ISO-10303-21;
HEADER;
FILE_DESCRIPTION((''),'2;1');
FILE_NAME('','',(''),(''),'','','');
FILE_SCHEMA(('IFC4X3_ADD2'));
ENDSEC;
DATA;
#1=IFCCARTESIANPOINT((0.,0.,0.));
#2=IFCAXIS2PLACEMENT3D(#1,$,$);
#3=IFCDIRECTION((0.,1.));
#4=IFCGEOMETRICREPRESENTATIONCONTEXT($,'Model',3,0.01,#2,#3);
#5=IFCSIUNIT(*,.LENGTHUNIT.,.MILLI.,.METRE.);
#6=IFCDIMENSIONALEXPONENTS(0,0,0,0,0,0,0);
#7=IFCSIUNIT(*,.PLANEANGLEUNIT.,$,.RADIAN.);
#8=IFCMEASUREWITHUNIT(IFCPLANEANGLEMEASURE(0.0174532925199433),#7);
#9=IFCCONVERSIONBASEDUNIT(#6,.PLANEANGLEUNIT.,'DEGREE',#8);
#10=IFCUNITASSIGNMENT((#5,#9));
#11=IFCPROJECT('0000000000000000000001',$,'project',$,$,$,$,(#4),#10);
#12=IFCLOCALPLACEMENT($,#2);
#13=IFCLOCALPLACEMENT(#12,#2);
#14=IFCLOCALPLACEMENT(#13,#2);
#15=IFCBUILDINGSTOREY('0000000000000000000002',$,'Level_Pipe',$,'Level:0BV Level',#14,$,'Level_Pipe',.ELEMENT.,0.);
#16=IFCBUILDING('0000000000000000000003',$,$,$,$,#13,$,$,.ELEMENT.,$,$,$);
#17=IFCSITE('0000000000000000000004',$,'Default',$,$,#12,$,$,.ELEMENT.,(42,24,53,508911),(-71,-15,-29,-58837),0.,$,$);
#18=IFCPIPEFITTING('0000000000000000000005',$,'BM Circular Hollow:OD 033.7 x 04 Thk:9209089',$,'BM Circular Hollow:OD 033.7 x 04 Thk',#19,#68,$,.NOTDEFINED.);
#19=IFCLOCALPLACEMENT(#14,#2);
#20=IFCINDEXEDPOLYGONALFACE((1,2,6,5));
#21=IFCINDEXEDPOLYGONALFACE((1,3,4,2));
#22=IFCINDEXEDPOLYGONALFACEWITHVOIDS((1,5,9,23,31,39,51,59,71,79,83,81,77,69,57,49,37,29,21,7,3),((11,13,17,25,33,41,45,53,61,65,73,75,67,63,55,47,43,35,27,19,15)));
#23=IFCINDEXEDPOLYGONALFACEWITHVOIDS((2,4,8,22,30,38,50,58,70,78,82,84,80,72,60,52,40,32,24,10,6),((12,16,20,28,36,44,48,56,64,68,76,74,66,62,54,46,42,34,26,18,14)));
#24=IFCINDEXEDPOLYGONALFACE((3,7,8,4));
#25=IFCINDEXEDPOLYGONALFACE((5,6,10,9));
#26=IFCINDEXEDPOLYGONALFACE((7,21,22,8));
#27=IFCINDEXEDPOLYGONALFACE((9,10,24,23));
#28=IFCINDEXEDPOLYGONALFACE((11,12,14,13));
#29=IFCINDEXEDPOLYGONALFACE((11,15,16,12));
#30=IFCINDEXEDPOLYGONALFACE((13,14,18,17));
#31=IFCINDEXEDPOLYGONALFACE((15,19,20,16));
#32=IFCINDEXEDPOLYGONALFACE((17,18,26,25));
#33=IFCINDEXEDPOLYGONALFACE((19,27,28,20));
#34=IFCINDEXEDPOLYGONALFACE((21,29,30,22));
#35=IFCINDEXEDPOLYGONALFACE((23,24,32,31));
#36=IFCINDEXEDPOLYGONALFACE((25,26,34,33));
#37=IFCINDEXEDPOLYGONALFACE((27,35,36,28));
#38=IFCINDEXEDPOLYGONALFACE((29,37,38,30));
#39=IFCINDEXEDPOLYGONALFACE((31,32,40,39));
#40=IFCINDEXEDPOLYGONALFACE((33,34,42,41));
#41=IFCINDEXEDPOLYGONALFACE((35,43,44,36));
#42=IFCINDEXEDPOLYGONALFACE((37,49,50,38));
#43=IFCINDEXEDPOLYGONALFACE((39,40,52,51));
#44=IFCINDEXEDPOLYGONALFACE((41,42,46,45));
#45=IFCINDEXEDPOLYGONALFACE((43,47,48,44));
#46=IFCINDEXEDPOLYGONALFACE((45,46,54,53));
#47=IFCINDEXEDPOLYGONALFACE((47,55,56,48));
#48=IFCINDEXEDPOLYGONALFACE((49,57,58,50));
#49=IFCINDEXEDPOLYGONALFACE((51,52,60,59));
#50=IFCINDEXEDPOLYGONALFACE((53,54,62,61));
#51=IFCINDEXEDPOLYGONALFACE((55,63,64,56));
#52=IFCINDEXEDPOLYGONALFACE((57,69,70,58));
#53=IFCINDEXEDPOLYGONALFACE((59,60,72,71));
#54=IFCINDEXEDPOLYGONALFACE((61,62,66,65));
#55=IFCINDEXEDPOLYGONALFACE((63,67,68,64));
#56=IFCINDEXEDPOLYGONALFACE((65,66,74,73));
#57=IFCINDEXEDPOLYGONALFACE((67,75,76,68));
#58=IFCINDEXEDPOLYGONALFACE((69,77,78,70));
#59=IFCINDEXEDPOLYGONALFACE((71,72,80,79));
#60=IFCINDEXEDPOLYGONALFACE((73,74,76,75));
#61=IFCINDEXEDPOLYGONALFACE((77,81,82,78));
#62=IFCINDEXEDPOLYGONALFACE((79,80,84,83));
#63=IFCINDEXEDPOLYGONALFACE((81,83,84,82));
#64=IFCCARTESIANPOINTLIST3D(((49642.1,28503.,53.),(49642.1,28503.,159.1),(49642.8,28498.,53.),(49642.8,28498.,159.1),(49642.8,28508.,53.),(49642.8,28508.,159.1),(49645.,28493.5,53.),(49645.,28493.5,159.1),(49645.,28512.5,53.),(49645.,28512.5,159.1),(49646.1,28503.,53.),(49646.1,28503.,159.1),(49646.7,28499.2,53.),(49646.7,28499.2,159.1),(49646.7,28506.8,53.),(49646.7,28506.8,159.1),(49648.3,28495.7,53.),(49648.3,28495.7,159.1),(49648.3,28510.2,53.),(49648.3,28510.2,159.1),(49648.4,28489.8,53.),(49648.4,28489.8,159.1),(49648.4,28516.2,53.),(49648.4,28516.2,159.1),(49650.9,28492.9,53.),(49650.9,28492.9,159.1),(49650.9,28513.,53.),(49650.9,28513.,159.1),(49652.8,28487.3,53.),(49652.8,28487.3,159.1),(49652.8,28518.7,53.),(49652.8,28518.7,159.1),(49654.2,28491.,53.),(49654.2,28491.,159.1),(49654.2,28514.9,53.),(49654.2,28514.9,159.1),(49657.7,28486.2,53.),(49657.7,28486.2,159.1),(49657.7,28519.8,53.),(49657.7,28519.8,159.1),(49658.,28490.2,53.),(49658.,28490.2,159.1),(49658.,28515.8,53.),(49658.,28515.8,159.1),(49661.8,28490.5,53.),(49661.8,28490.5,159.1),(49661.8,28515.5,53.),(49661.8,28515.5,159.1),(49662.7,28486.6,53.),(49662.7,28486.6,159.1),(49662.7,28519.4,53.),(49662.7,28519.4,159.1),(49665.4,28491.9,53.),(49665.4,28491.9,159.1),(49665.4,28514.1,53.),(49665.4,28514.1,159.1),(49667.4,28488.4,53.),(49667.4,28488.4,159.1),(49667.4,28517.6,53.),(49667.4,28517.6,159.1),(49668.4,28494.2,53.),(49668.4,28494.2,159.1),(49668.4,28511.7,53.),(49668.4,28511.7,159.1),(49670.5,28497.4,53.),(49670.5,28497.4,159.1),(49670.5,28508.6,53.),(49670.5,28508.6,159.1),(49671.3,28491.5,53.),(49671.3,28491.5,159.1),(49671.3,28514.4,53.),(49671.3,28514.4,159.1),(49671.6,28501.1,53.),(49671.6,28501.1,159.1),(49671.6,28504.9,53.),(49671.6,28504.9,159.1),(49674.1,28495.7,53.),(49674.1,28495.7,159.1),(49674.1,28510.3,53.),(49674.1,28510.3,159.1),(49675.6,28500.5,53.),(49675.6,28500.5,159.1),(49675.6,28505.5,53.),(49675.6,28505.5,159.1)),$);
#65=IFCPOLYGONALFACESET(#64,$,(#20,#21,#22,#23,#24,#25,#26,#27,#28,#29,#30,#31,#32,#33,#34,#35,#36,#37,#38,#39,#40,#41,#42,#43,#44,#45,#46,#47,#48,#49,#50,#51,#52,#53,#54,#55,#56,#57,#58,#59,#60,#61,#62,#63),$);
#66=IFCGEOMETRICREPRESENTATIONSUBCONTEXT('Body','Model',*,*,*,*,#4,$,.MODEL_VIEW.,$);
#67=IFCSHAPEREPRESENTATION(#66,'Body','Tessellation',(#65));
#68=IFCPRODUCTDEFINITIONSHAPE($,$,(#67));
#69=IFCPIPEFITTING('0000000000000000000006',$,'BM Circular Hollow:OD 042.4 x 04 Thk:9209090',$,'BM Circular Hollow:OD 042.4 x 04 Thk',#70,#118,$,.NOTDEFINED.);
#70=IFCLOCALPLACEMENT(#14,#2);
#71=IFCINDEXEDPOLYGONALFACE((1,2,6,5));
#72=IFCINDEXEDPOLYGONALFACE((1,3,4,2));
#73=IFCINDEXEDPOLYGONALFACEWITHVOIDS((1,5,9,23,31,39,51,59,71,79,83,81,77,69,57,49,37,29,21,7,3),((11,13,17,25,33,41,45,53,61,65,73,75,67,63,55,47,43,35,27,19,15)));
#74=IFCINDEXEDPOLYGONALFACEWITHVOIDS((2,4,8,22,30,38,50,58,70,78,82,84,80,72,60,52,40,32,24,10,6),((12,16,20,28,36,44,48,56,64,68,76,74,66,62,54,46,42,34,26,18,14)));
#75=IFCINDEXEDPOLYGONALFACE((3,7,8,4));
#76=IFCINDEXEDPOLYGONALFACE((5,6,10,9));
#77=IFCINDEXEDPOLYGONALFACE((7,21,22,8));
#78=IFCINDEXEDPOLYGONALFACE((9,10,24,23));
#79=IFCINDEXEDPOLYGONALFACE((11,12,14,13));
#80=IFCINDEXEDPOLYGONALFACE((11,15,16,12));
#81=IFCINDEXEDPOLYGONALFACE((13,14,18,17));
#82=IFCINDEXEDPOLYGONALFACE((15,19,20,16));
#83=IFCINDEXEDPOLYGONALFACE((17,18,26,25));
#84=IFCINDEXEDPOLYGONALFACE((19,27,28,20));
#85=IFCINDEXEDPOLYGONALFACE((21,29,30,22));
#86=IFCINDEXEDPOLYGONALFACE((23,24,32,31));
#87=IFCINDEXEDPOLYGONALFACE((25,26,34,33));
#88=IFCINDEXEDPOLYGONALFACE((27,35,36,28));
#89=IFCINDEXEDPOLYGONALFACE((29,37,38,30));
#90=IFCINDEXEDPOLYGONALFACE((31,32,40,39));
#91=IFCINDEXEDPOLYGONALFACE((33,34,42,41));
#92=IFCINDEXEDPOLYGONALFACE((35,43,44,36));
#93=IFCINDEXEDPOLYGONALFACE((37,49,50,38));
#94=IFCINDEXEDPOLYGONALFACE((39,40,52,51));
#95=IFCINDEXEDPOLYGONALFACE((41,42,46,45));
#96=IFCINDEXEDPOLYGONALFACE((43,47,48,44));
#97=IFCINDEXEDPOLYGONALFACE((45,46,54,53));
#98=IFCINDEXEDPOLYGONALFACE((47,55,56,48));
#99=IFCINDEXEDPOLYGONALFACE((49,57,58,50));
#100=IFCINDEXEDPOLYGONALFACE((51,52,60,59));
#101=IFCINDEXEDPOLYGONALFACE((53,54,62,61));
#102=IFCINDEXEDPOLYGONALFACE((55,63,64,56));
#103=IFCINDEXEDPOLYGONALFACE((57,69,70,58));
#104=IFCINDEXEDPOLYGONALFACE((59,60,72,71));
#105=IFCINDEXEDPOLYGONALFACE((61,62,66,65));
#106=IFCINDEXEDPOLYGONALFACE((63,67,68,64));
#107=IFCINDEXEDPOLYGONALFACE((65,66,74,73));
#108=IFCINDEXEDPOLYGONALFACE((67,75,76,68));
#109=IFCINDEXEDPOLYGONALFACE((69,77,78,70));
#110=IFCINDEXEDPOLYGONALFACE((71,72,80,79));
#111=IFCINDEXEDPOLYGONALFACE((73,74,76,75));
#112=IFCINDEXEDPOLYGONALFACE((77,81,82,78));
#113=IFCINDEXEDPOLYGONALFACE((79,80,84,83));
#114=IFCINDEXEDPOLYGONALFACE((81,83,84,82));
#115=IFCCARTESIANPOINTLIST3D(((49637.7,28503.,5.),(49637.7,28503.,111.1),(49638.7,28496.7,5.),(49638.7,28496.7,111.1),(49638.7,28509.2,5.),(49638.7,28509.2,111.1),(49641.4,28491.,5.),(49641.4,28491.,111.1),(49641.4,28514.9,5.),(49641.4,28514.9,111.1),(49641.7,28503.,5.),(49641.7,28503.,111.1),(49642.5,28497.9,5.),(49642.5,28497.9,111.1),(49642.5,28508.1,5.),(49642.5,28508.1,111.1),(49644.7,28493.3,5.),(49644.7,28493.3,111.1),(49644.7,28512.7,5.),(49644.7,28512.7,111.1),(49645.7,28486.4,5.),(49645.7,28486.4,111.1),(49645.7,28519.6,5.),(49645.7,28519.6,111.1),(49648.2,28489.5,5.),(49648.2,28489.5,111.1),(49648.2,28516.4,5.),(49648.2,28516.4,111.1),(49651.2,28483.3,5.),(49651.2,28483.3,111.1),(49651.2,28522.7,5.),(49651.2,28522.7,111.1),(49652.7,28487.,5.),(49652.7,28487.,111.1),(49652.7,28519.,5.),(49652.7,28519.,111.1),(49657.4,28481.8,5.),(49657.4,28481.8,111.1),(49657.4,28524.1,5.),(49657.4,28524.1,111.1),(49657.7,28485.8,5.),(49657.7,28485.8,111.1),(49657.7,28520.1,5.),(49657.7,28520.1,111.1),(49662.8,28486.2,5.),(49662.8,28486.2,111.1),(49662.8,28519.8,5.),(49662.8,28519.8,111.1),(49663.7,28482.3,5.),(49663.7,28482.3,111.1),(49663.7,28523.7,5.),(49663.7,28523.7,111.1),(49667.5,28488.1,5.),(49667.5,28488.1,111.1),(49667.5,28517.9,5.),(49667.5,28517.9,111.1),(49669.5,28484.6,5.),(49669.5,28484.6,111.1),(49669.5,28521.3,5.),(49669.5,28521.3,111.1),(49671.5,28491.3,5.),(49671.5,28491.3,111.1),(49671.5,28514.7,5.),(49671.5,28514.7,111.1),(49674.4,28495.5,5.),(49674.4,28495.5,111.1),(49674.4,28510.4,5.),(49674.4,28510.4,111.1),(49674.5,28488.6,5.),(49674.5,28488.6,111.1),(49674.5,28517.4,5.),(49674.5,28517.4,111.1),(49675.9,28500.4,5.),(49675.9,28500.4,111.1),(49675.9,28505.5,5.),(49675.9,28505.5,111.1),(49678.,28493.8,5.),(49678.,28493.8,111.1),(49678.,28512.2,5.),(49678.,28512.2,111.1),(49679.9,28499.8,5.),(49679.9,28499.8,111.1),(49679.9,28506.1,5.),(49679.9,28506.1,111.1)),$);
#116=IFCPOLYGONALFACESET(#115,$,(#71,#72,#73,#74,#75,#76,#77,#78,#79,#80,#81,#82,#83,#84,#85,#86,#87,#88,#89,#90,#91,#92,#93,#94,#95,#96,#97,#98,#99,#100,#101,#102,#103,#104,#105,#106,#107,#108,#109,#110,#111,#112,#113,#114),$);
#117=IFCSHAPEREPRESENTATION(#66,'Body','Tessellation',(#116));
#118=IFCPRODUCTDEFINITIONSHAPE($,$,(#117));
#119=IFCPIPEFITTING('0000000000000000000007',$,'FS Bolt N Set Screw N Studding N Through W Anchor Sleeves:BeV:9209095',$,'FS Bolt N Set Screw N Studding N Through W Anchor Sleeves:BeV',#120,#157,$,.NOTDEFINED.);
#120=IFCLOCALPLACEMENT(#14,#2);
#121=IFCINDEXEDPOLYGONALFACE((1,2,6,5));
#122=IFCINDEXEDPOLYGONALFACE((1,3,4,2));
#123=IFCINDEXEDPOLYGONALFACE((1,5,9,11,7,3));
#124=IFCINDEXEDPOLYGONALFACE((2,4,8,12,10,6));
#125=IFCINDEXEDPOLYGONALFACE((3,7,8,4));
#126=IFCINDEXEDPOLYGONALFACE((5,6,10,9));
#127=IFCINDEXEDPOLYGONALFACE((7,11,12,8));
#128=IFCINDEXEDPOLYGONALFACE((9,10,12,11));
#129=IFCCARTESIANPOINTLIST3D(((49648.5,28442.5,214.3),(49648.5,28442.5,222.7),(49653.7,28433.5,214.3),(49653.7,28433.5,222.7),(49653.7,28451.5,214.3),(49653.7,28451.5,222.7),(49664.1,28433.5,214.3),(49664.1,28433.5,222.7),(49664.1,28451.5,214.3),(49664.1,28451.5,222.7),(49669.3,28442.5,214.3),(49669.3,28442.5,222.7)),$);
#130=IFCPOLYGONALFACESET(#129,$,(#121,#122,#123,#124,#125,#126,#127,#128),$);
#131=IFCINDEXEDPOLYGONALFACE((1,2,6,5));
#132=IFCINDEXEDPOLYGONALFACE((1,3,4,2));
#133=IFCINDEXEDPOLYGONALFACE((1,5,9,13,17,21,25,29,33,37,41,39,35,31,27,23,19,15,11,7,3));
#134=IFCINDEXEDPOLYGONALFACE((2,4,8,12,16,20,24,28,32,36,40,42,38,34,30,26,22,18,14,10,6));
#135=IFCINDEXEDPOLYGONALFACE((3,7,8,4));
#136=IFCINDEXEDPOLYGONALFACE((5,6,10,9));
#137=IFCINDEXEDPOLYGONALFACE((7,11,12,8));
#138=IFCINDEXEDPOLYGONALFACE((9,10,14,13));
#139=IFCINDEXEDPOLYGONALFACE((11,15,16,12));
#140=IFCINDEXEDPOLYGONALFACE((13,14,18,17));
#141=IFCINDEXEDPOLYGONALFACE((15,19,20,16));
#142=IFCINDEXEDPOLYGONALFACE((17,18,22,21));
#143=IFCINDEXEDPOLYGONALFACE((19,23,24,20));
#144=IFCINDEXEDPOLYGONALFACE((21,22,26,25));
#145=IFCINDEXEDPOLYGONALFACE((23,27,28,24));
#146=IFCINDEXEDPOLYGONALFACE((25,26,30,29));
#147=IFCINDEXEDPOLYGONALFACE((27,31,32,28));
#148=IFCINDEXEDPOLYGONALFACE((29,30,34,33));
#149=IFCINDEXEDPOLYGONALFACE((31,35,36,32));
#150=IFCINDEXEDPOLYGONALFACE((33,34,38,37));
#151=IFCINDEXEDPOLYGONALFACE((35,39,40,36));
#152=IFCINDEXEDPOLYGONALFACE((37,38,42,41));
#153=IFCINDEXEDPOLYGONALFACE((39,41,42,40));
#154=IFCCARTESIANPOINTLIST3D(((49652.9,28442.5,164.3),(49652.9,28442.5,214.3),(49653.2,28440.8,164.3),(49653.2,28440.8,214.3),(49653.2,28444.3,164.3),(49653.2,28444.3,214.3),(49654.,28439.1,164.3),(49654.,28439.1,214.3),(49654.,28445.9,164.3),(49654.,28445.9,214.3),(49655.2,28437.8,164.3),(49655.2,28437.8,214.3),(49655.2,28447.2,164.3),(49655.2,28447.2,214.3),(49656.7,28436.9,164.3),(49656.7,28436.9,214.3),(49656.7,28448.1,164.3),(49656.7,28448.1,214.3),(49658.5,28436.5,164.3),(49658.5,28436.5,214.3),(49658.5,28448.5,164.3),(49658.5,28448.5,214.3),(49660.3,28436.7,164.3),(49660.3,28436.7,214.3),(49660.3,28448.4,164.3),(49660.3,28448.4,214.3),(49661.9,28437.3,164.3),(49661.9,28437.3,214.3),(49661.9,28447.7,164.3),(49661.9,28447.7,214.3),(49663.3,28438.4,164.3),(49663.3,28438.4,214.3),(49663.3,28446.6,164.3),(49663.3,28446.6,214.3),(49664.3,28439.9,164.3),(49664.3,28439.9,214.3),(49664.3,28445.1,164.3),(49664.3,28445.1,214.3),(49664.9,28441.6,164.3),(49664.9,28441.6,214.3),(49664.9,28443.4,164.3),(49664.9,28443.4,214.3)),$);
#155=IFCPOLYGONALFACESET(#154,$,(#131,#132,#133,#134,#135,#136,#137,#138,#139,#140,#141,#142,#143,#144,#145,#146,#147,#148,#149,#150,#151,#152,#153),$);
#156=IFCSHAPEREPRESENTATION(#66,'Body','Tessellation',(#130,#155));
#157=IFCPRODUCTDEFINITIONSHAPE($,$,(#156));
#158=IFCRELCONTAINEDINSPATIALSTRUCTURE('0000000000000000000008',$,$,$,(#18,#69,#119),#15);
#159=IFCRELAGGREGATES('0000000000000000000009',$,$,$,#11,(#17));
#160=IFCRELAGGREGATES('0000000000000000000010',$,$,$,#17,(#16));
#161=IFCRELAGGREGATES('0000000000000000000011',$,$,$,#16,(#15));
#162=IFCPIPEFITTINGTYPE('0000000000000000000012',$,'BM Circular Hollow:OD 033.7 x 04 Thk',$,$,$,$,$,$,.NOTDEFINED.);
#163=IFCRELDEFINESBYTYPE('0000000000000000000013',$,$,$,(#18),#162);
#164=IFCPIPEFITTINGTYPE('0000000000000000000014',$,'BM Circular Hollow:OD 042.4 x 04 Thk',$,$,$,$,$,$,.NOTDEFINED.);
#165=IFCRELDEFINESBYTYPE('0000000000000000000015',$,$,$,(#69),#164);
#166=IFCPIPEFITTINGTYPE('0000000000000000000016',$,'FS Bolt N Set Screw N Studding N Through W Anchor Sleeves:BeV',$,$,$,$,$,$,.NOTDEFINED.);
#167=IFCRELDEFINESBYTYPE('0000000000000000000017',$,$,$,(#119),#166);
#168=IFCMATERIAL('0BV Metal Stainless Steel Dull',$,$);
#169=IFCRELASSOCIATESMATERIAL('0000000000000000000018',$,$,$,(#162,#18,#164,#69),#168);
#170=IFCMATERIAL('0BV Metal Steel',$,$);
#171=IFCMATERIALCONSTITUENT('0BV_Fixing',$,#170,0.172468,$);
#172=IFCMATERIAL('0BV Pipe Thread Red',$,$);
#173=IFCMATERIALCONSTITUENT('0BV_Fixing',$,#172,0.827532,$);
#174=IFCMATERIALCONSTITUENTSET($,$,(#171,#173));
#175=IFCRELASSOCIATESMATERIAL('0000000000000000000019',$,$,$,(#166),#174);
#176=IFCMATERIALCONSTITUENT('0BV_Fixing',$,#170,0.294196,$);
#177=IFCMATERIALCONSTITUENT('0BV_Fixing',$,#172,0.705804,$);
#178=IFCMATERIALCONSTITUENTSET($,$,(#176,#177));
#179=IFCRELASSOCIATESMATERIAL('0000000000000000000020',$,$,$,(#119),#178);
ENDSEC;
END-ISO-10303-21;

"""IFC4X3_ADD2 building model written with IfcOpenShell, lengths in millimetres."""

from ifc_helpers import new_model, entity, si_unit, converted_unit, direction, frame, frame_2d, origin, place, context, subcontext, project, spatial, polyline, circle, hollow_circle, outline, extrude, source, transform, mapped, material, constituent, constituent_set, type_object, type_shapes, element, save


model = new_model("IFC4X3_ADD2")

# Units and contexts
model_context = context("Model", 3, precision=0.01, world=origin(), true_north=direction((0.0, 1.0)))
body_context = subcontext(model_context, "Body", "Model", "MODEL_VIEW")
ifc_project = project(units=[si_unit("LENGTHUNIT", "METRE", prefix="MILLI"), converted_unit("PLANEANGLEUNIT", "DEGREE", entity("IfcPlaneAngleMeasure", 0.0174532925199433), si_unit("PLANEANGLEUNIT", "RADIAN"), dimensions=[0, 0, 0, 0, 0, 0, 0])], contexts=[model_context])

# Site, building, storey
site_placement = place(None, origin())
site = spatial("IfcSite", under=ifc_project, at=site_placement, Name="Default", CompositionType="ELEMENT", RefLatitude=(42, 24, 53, 508911), RefLongitude=(-71, -15, -29, -58837), RefElevation=0.0)
building_placement = place(site_placement, origin())
building = spatial("IfcBuilding", under=site, at=building_placement, CompositionType="ELEMENT")
storey_placement = place(building_placement, origin())
storey = spatial("IfcBuildingStorey", under=building, at=storey_placement, Name="Level_Pipe", ObjectType="Level:0BV Level", LongName="Level_Pipe", CompositionType="ELEMENT", Elevation=0.0)

# Shared definitions
ifc_material_1 = material(Name="0BV Metal Stainless Steel Dull")

# Pipe fittings
ifc_material_2 = material(Name="0BV Metal Steel")
ifc_material_3 = material(Name="0BV Pipe Thread Red")
pipe_fitting_type_1 = type_object("IfcPipeFittingType", Name="BM Circular Hollow:OD 033.7 x 04 Thk", PredefinedType="NOTDEFINED", material=ifc_material_1)
shared_shape_1 = source(origin(), body_context, "Body", "SweptSolid", [
    extrude(hollow_circle(Radius=16.9, WallThickness=4.0, at=frame_2d((0.0, 0.0), x_axis=(1.0, 0.0))), frame((-53.0, 0.0, 0.0), z_axis=(1.0, 0.0, 0.0), x_axis=(0.0, -1.0, 0.0)), (0.0, 0.0, 1.0), 106.1),
])
type_shapes(pipe_fitting_type_1, [shared_shape_1])
pipe_fitting_1_placement = place(storey_placement, frame((49658.9, 28503.0, 106.1), z_axis=(0.0, 1.0, 0.0), x_axis=(0.0, 0.0, 1.0)))
element("IfcPipeFitting", 1, at=pipe_fitting_1_placement, inside=storey, type_object=pipe_fitting_type_1, material=ifc_material_1, Name="BM Circular Hollow:OD 033.7 x 04 Thk:9209089", ObjectType="BM Circular Hollow:OD 033.7 x 04 Thk", PredefinedType="NOTDEFINED", context=body_context, shape_type="MappedRepresentation", body=[
    mapped(shared_shape_1, transform((0.0, 0.0, 0.0), scale=1.0)),
])
pipe_fitting_type_2 = type_object("IfcPipeFittingType", Name="BM Circular Hollow:OD 042.4 x 04 Thk", PredefinedType="NOTDEFINED", material=ifc_material_1)
shared_shape_2 = source(origin(), body_context, "Body", "SweptSolid", [
    extrude(hollow_circle(Radius=21.2, WallThickness=4.0, at=frame_2d((0.0, 0.0), x_axis=(1.0, 0.0))), frame((-53.0, 0.0, 0.0), z_axis=(1.0, 0.0, 0.0), x_axis=(0.0, -1.0, 0.0)), (0.0, 0.0, 1.0), 106.1),
])
type_shapes(pipe_fitting_type_2, [shared_shape_2])
pipe_fitting_2_placement = place(storey_placement, frame((49658.9, 28503.0, 58.0), z_axis=(0.0, 1.0, 0.0), x_axis=(0.0, 0.0, 1.0)))
element("IfcPipeFitting", 2, at=pipe_fitting_2_placement, inside=storey, type_object=pipe_fitting_type_2, material=ifc_material_1, Name="BM Circular Hollow:OD 042.4 x 04 Thk:9209090", ObjectType="BM Circular Hollow:OD 042.4 x 04 Thk", PredefinedType="NOTDEFINED", context=body_context, shape_type="MappedRepresentation", body=[
    mapped(shared_shape_2, transform((0.0, 0.0, 0.0), scale=1.0)),
])
ifc_constituent_1 = constituent(ifc_material_2, Name="0BV_Fixing", fraction=0.294196)
ifc_constituent_2 = constituent(ifc_material_3, Name="0BV_Fixing", fraction=0.705804)
ifc_constituent_set_1 = constituent_set(constituents=[ifc_constituent_1, ifc_constituent_2])
ifc_constituent_3 = constituent(ifc_material_2, Name="0BV_Fixing", fraction=0.172468)
ifc_constituent_4 = constituent(ifc_material_3, Name="0BV_Fixing", fraction=0.827532)
ifc_constituent_set_2 = constituent_set(constituents=[ifc_constituent_3, ifc_constituent_4])
pipe_fitting_type_3 = type_object("IfcPipeFittingType", Name="FS Bolt N Set Screw N Studding N Through W Anchor Sleeves:BeV", PredefinedType="NOTDEFINED", material=ifc_constituent_set_2)
shared_shape_3 = source(origin(), body_context, "Body", "SweptSolid", [
    extrude(outline(polyline([(-5.2, -9.0), (5.2, -9.0), (10.4, 0.0), (5.2, 9.0), (-5.2, 9.0), (-10.4, 0.0), (-5.2, -9.0)])), frame((-8.4, 0.0, 0.0), z_axis=(1.0, 0.0, 0.0), x_axis=(0.0, -1.0, 0.0)), (0.0, 0.0, 1.0), 8.4),
    extrude(circle(Radius=6.0, at=frame_2d((0.0, 0.0), x_axis=(1.0, 0.0))), frame((0.0, 0.0, 0.0), z_axis=(1.0, 0.0, 0.0), x_axis=(0.0, -1.0, 0.0)), (0.0, 0.0, 1.0), 50.0),
])
type_shapes(pipe_fitting_type_3, [shared_shape_3])
pipe_fitting_3_placement = place(storey_placement, frame((49658.9, 28442.5, 214.3), z_axis=(0.0, -1.0, 0.0), x_axis=(0.0, 0.0, -1.0)))
element("IfcPipeFitting", 3, at=pipe_fitting_3_placement, inside=storey, type_object=pipe_fitting_type_3, material=ifc_constituent_set_1, Name="FS Bolt N Set Screw N Studding N Through W Anchor Sleeves:BeV:9209095", ObjectType="FS Bolt N Set Screw N Studding N Through W Anchor Sleeves:BeV", PredefinedType="NOTDEFINED", context=body_context, shape_type="MappedRepresentation", body=[
    mapped(shared_shape_3, transform((0.0, 0.0, 0.0), scale=1.0)),
])

save(model, "model.ifc")
